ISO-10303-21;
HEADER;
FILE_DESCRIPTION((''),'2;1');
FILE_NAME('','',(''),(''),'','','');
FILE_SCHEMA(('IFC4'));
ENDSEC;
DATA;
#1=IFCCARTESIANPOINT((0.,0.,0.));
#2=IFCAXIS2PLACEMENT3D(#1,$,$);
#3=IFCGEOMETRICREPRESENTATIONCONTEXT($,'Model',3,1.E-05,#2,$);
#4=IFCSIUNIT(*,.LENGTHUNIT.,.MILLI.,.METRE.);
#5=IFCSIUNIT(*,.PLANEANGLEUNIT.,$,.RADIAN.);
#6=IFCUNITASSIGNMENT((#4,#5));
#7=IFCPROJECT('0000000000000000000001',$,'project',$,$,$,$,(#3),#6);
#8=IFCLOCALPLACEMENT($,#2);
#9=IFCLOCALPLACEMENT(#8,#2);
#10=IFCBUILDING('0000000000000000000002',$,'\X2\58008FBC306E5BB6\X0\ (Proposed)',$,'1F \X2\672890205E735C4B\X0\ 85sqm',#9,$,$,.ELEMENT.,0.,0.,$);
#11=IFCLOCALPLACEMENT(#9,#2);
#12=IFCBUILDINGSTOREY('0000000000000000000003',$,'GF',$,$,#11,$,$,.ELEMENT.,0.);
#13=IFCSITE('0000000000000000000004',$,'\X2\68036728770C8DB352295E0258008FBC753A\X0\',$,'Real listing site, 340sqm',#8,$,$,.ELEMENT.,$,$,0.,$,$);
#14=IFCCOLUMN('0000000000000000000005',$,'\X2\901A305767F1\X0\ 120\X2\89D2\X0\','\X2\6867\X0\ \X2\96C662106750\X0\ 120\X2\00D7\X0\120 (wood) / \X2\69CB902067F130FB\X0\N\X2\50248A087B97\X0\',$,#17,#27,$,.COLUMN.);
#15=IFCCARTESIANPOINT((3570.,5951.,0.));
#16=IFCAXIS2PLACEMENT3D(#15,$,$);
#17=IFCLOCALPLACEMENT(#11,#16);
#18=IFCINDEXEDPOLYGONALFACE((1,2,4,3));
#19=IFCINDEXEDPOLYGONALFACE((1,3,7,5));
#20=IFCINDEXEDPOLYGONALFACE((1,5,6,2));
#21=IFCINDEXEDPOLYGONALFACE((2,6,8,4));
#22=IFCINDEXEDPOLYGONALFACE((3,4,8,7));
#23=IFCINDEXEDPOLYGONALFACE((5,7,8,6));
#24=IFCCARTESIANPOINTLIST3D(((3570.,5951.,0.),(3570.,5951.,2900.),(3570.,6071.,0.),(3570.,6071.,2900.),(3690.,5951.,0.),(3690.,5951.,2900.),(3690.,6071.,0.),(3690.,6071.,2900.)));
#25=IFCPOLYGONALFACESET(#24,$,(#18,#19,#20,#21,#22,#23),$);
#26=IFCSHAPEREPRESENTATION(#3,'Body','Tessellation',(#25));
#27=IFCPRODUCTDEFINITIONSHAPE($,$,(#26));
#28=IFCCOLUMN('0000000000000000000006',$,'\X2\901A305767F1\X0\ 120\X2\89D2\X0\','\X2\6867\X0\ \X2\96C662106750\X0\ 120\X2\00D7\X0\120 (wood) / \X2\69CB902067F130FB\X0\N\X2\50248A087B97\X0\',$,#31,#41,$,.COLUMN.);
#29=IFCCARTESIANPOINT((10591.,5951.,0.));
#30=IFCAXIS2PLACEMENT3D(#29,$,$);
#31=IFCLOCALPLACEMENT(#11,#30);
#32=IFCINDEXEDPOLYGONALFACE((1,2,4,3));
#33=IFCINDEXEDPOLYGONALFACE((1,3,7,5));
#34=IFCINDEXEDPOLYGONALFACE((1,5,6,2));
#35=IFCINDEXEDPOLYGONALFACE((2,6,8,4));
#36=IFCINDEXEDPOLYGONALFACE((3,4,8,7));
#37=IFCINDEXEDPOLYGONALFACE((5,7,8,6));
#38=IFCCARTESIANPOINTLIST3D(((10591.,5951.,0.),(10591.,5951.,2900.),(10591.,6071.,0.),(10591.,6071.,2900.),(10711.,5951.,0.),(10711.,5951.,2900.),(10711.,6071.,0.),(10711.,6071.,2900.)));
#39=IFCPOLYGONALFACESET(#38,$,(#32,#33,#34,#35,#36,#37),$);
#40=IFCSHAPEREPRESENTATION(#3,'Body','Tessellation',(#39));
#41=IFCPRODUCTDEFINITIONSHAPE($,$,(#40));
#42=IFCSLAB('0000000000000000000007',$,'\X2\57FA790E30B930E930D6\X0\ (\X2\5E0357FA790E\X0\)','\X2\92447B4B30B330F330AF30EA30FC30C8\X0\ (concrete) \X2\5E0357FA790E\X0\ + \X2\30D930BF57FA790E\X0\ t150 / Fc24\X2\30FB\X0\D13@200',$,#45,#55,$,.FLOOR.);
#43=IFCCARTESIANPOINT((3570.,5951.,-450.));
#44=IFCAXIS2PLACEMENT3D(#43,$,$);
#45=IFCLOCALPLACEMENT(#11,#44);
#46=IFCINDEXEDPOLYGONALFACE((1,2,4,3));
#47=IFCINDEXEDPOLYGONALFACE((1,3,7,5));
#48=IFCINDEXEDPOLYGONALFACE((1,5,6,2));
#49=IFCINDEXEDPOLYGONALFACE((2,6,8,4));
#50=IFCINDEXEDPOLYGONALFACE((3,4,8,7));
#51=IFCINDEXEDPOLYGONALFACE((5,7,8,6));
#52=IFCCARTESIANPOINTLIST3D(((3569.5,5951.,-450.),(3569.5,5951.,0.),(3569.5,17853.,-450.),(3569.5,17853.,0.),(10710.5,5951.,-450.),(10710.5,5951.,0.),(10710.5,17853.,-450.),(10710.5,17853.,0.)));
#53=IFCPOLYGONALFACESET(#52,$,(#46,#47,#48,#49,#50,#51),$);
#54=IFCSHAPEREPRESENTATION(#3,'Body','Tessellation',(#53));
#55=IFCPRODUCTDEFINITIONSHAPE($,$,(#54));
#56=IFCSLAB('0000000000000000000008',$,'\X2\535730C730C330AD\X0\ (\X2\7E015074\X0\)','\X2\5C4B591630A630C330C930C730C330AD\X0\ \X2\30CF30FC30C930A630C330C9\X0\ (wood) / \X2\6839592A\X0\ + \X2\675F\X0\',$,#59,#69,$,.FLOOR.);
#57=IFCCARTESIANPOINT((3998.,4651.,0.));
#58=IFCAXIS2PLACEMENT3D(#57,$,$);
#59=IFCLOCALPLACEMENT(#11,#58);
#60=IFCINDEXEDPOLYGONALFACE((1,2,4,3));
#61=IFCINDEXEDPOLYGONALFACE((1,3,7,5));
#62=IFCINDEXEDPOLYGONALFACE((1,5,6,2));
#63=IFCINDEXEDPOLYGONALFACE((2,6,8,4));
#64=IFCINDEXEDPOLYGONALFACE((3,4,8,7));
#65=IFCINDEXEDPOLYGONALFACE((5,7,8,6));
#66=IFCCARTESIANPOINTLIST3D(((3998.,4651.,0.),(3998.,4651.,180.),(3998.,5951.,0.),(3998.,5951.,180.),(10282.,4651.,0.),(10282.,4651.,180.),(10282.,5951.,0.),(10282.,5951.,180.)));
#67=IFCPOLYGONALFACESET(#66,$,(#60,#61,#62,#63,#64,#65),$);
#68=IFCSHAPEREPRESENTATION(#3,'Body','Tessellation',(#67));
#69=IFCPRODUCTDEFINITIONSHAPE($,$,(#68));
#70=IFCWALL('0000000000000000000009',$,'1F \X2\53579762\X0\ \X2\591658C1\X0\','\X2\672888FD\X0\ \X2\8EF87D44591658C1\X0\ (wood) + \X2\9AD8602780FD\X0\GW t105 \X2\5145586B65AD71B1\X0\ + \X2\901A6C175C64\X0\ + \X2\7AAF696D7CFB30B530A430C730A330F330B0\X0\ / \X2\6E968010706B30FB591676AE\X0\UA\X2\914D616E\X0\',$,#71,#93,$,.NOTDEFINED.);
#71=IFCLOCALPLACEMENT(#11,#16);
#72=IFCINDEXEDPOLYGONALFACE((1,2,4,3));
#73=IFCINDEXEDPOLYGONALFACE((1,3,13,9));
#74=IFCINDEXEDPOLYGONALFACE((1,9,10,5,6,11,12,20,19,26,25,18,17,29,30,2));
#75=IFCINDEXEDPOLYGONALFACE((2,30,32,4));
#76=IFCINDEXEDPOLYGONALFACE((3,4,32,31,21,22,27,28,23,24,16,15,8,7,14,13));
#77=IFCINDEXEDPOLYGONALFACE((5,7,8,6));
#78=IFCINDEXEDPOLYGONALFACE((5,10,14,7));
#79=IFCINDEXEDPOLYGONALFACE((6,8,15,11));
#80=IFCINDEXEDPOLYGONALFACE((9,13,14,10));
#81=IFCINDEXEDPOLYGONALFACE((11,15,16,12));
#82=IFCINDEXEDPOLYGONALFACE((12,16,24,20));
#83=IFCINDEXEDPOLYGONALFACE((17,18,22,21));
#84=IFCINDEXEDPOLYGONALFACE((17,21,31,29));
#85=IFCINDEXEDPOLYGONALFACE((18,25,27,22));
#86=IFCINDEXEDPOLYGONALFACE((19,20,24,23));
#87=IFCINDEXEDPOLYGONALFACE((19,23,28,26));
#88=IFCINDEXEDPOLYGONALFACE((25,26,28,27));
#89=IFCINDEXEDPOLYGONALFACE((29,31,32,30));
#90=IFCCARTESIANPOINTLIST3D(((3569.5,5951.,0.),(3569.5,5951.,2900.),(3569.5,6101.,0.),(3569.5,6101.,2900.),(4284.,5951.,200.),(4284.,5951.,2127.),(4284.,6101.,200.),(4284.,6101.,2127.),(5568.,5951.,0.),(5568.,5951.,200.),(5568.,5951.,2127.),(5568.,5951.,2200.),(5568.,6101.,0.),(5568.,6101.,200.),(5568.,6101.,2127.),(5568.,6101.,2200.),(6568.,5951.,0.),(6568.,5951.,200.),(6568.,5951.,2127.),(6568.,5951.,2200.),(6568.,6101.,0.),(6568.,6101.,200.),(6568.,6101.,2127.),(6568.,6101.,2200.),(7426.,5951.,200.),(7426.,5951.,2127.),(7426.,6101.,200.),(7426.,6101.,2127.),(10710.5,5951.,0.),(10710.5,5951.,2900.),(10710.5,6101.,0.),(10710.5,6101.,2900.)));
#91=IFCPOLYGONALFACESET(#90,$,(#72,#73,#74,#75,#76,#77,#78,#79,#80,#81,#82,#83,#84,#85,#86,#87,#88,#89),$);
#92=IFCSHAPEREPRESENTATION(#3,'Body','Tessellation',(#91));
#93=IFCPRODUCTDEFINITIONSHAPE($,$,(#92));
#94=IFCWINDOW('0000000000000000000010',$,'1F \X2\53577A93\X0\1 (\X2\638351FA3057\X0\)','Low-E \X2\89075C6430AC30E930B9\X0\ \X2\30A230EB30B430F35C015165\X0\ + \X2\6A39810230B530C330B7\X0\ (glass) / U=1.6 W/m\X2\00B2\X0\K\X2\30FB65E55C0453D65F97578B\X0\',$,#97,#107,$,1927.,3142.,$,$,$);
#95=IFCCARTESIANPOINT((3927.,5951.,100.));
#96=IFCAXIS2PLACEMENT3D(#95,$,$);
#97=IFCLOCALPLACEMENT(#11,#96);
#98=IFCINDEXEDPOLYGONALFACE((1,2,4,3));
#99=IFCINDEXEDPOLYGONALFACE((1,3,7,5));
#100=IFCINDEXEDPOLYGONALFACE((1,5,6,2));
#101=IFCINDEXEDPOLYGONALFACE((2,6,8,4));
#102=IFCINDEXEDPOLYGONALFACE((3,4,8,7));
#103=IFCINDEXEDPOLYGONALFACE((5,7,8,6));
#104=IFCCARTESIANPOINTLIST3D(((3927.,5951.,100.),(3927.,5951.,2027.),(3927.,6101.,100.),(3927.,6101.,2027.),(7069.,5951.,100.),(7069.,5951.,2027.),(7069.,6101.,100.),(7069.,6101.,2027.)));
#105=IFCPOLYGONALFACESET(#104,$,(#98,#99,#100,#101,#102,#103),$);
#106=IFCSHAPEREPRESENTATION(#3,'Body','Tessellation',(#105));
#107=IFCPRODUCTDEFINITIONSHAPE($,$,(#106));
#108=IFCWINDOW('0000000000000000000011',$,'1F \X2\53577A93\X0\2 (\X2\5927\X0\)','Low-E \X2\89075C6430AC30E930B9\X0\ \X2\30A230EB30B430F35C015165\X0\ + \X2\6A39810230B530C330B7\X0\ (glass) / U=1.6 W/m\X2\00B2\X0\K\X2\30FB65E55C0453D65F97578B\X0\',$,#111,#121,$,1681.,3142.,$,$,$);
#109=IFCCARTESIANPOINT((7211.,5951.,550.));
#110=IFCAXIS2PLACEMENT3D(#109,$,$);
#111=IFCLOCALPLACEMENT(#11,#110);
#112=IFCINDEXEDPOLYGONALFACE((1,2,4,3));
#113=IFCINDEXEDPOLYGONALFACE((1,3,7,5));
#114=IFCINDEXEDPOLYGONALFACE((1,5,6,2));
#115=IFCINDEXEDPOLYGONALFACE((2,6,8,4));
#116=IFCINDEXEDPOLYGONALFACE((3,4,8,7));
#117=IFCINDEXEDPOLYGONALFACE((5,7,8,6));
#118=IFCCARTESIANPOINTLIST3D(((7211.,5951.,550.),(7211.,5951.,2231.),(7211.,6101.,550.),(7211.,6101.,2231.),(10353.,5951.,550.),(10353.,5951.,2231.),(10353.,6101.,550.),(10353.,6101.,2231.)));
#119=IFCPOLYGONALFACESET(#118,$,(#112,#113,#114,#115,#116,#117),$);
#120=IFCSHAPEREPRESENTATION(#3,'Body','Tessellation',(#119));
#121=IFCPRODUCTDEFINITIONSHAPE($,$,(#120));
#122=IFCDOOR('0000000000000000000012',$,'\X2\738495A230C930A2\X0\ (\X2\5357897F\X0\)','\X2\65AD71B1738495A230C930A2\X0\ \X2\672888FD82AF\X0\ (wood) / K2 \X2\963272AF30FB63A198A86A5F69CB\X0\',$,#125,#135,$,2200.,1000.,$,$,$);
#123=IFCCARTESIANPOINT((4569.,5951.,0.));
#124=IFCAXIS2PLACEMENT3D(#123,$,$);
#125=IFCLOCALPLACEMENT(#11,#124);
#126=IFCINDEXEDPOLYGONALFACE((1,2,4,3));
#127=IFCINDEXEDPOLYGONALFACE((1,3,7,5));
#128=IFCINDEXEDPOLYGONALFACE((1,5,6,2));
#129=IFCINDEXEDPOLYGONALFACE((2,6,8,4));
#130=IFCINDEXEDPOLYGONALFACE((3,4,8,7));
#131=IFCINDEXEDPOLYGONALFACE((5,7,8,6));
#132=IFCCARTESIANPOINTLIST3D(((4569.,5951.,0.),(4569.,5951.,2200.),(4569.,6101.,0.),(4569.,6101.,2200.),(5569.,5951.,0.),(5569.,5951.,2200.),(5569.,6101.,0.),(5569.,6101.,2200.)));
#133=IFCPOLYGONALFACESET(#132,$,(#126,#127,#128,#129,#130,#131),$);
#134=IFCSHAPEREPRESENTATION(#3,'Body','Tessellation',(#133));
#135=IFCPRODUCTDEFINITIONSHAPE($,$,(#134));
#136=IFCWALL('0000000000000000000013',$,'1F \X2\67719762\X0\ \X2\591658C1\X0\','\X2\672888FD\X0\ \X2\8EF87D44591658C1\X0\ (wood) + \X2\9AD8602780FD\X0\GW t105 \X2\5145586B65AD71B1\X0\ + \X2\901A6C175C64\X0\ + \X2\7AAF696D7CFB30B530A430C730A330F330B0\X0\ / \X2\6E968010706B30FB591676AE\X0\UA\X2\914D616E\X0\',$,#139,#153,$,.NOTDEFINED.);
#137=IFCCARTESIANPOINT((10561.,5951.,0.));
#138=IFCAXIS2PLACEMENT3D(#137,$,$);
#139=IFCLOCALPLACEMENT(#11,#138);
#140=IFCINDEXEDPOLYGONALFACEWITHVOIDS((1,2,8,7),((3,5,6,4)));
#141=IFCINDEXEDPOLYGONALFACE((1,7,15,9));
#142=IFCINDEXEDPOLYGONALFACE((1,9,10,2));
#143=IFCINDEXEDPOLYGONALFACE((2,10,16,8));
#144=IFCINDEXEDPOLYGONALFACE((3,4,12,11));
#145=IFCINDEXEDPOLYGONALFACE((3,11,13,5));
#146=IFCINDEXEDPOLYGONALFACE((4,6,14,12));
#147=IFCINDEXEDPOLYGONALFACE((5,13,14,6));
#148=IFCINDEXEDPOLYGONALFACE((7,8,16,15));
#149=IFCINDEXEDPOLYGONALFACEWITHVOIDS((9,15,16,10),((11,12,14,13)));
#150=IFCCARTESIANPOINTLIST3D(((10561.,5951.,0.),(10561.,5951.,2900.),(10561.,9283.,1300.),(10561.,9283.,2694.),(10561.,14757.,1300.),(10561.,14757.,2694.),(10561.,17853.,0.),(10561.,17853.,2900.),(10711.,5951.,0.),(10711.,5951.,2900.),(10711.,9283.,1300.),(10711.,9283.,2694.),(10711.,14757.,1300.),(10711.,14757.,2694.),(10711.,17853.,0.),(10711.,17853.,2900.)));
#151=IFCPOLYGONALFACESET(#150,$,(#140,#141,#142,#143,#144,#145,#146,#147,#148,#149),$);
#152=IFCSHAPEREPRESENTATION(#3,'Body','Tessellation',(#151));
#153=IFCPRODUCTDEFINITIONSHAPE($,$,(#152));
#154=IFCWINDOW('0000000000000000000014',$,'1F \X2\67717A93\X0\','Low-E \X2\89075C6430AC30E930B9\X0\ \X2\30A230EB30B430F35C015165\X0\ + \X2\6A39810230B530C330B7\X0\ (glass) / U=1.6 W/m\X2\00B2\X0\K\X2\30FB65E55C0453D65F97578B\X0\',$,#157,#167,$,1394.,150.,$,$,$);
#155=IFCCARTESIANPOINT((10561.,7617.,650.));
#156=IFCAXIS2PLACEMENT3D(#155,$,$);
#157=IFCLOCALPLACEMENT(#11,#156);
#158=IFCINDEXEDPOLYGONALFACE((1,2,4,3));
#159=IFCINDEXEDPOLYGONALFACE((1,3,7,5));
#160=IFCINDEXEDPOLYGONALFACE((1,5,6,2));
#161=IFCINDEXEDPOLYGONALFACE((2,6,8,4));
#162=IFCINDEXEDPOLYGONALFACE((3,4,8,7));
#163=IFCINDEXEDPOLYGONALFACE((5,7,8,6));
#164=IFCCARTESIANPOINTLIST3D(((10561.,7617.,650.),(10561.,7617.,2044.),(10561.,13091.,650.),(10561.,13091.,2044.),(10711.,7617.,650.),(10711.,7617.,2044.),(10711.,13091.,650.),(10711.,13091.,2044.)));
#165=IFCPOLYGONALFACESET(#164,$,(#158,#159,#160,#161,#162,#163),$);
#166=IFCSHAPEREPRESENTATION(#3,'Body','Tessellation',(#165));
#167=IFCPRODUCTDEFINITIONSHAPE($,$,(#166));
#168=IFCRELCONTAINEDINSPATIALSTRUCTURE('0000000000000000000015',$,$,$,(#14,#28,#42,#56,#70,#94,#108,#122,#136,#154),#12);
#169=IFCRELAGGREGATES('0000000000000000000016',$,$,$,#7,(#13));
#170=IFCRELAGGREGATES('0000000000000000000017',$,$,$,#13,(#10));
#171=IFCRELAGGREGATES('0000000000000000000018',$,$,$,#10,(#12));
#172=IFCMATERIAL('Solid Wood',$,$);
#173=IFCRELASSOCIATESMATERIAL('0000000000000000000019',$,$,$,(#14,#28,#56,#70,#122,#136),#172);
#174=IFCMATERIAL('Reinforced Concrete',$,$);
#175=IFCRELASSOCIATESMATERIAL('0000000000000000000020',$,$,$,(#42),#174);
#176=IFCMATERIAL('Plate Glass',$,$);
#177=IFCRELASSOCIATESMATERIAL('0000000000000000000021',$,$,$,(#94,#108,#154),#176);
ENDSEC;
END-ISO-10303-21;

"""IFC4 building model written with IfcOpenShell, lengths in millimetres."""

from ifc_helpers import new_model, si_unit, frame, frame_2d, origin, place, context, project, spatial, rectangle, extrude, material, element, fill, save


model = new_model("IFC4")

# Units and contexts
model_context = context("Model", 3, precision=1e-05, world=origin())
ifc_project = project(units=[si_unit("LENGTHUNIT", "METRE", prefix="MILLI"), si_unit("PLANEANGLEUNIT", "RADIAN")], contexts=[model_context])

# Site, building, storey
site_placement = place(None, origin())
site = spatial("IfcSite", under=ifc_project, at=site_placement, Name="栃木県足利市堀込町", ObjectType="Real listing site, 340sqm", CompositionType="ELEMENT", RefElevation=0.0)
building_placement = place(site_placement, origin())
building = spatial("IfcBuilding", under=site, at=building_placement, Name="堀込の家 (Proposed)", ObjectType="1F 木造平屋 85sqm", CompositionType="ELEMENT", ElevationOfRefHeight=0.0, ElevationOfTerrain=0.0)
storey_placement = place(building_placement, origin())
storey = spatial("IfcBuildingStorey", under=building, at=storey_placement, Name="GF", CompositionType="ELEMENT", Elevation=0.0)

# Columns
ifc_material_1 = material(Name="Solid Wood")
column_1_placement = place(storey_placement, frame((3570.0, 5951.0, 0.0)))
element("IfcColumn", 1, at=column_1_placement, inside=storey, material=ifc_material_1, Name="通し柱 120角", Description="桧 集成材 120×120 (wood) / 構造柱・N値計算", PredefinedType="COLUMN", context=model_context, shape_type="SweptSolid", body=[
    extrude(rectangle(XDim=120.0, YDim=120.0, at=frame_2d((60.0, 60.0))), frame((3570.0, 5951.0, 0.0)), (0.0, 0.0, 1.0), 2900.0),
])
column_2_placement = place(storey_placement, frame((10591.0, 5951.0, 0.0)))
element("IfcColumn", 2, at=column_2_placement, inside=storey, material=ifc_material_1, Name="通し柱 120角", Description="桧 集成材 120×120 (wood) / 構造柱・N値計算", PredefinedType="COLUMN", context=model_context, shape_type="SweptSolid", body=[
    extrude(rectangle(XDim=120.0, YDim=120.0, at=frame_2d((60.0, 60.0))), frame((10591.0, 5951.0, 0.0)), (0.0, 0.0, 1.0), 2900.0),
])

# Slabs
ifc_material_2 = material(Name="Reinforced Concrete")
slab_1_placement = place(storey_placement, frame((3570.0, 5951.0, -450.0)))
element("IfcSlab", 3, at=slab_1_placement, inside=storey, material=ifc_material_2, Name="基礎スラブ (布基礎)", Description="鉄筋コンクリート (concrete) 布基礎 + ベタ基礎 t150 / Fc24・D13@200", PredefinedType="FLOOR", context=model_context, shape_type="SweptSolid", body=[
    extrude(rectangle(XDim=7141.0, YDim=11902.0, at=frame_2d((3570.0, 5951.0))), frame((3570.0, 5951.0, -450.0)), (0.0, 0.0, 1.0), 450.0),
])
slab_2_placement = place(storey_placement, frame((3998.0, 4651.0, 0.0)))
element("IfcSlab", 4, at=slab_2_placement, inside=storey, material=ifc_material_1, Name="南デッキ (縁側)", Description="屋外ウッドデッキ ハードウッド (wood) / 根太 + 束", PredefinedType="FLOOR", context=model_context, shape_type="SweptSolid", body=[
    extrude(rectangle(XDim=6284.0, YDim=1300.0, at=frame_2d((3142.0, 650.0))), frame((3998.0, 4651.0, 0.0)), (0.0, 0.0, 1.0), 180.0),
])

# Wall, openings, windows, door
wall_1_placement = place(storey_placement, frame((3570.0, 5951.0, 0.0)))
wall_1 = element("IfcWall", 5, at=wall_1_placement, inside=storey, material=ifc_material_1, Name="1F 南面 外壁", Description="木製 軸組外壁 (wood) + 高性能GW t105 充填断熱 + 通気層 + 窯業系サイディング / 準耐火・外皮UA配慮", PredefinedType="NOTDEFINED", context=model_context, shape_type="SweptSolid", body=[
    extrude(rectangle(XDim=7141.0, YDim=150.0, at=frame_2d((3570.0, 75.0))), frame((3570.0, 5951.0, 0.0)), (0.0, 0.0, 1.0), 2900.0),
])
opening_1_placement = place(storey_placement, frame((3927.0, 5951.0, 100.0)))
opening_1 = element("IfcOpeningElement", 6, at=opening_1_placement, cuts=wall_1, PredefinedType="NOTDEFINED", context=model_context, shape_type="SweptSolid", body=[
    extrude(rectangle(XDim=3142.0, YDim=150.0, at=frame_2d((1571.0, 75.0))), frame((3927.0, 5951.0, 100.0)), (0.0, 0.0, 1.0), 1927.0),
])
opening_2_placement = place(storey_placement, frame((7211.0, 5951.0, 550.0)))
opening_2 = element("IfcOpeningElement", 7, at=opening_2_placement, cuts=wall_1, PredefinedType="NOTDEFINED", context=model_context, shape_type="SweptSolid", body=[
    extrude(rectangle(XDim=3142.0, YDim=150.0, at=frame_2d((1571.0, 75.0))), frame((7211.0, 5951.0, 550.0)), (0.0, 0.0, 1.0), 1681.0),
])
opening_3_placement = place(storey_placement, frame((4569.0, 5951.0, 0.0)))
opening_3 = element("IfcOpeningElement", 8, at=opening_3_placement, cuts=wall_1, PredefinedType="NOTDEFINED", context=model_context, shape_type="SweptSolid", body=[
    extrude(rectangle(XDim=1000.0, YDim=150.0, at=frame_2d((500.0, 75.0))), frame((4569.0, 5951.0, 0.0)), (0.0, 0.0, 1.0), 2200.0),
])
ifc_material_3 = material(Name="Plate Glass")
window_1_placement = place(storey_placement, frame((3927.0, 5951.0, 100.0)))
window_1 = element("IfcWindow", 9, at=window_1_placement, inside=storey, material=ifc_material_3, Name="1F 南窓1 (掃出し)", Description="Low-E 複層ガラス アルゴン封入 + 樹脂サッシ (glass) / U=1.6 W/m²K・日射取得型", OverallHeight=1927.0, OverallWidth=3142.0, context=model_context, shape_type="SweptSolid", body=[
    extrude(rectangle(XDim=3142.0, YDim=150.0, at=frame_2d((1571.0, 75.0))), frame((3927.0, 5951.0, 100.0)), (0.0, 0.0, 1.0), 1927.0),
])
fill(opening_1, window_1)
window_2_placement = place(storey_placement, frame((7211.0, 5951.0, 550.0)))
window_2 = element("IfcWindow", 10, at=window_2_placement, inside=storey, material=ifc_material_3, Name="1F 南窓2 (大)", Description="Low-E 複層ガラス アルゴン封入 + 樹脂サッシ (glass) / U=1.6 W/m²K・日射取得型", OverallHeight=1681.0, OverallWidth=3142.0, context=model_context, shape_type="SweptSolid", body=[
    extrude(rectangle(XDim=3142.0, YDim=150.0, at=frame_2d((1571.0, 75.0))), frame((7211.0, 5951.0, 550.0)), (0.0, 0.0, 1.0), 1681.0),
])
fill(opening_2, window_2)
door_placement = place(storey_placement, frame((4569.0, 5951.0, 0.0)))
door = element("IfcDoor", 11, at=door_placement, inside=storey, material=ifc_material_1, Name="玄関ドア (南西)", Description="断熱玄関ドア 木製芯 (wood) / K2 防犯・採風機構", OverallHeight=2200.0, OverallWidth=1000.0, context=model_context, shape_type="SweptSolid", body=[
    extrude(rectangle(XDim=1000.0, YDim=150.0, at=frame_2d((500.0, 75.0))), frame((4569.0, 5951.0, 0.0)), (0.0, 0.0, 1.0), 2200.0),
])
fill(opening_3, door)

# Wall, opening, window
wall_2_placement = place(storey_placement, frame((10561.0, 5951.0, 0.0)))
wall_2 = element("IfcWall", 12, at=wall_2_placement, inside=storey, material=ifc_material_1, Name="1F 東面 外壁", Description="木製 軸組外壁 (wood) + 高性能GW t105 充填断熱 + 通気層 + 窯業系サイディング / 準耐火・外皮UA配慮", PredefinedType="NOTDEFINED", context=model_context, shape_type="SweptSolid", body=[
    extrude(rectangle(XDim=150.0, YDim=11902.0, at=frame_2d((75.0, 5951.0))), frame((10561.0, 5951.0, 0.0)), (0.0, 0.0, 1.0), 2900.0),
])
opening_4_placement = place(storey_placement, frame((10561.0, 7617.0, 650.0)))
opening_4 = element("IfcOpeningElement", 13, at=opening_4_placement, cuts=wall_2, PredefinedType="NOTDEFINED", context=model_context, shape_type="SweptSolid", body=[
    extrude(rectangle(XDim=150.0, YDim=5474.0, at=frame_2d((75.0, 2737.0))), frame((10561.0, 7617.0, 650.0)), (0.0, 0.0, 1.0), 1394.0),
])
window_3_placement = place(storey_placement, frame((10561.0, 7617.0, 650.0)))
window_3 = element("IfcWindow", 14, at=window_3_placement, inside=storey, material=ifc_material_3, Name="1F 東窓", Description="Low-E 複層ガラス アルゴン封入 + 樹脂サッシ (glass) / U=1.6 W/m²K・日射取得型", OverallHeight=1394.0, OverallWidth=150.0, context=model_context, shape_type="SweptSolid", body=[
    extrude(rectangle(XDim=150.0, YDim=5474.0, at=frame_2d((75.0, 2737.0))), frame((10561.0, 7617.0, 650.0)), (0.0, 0.0, 1.0), 1394.0),
])
fill(opening_4, window_3)

save(model, "model.ifc")
